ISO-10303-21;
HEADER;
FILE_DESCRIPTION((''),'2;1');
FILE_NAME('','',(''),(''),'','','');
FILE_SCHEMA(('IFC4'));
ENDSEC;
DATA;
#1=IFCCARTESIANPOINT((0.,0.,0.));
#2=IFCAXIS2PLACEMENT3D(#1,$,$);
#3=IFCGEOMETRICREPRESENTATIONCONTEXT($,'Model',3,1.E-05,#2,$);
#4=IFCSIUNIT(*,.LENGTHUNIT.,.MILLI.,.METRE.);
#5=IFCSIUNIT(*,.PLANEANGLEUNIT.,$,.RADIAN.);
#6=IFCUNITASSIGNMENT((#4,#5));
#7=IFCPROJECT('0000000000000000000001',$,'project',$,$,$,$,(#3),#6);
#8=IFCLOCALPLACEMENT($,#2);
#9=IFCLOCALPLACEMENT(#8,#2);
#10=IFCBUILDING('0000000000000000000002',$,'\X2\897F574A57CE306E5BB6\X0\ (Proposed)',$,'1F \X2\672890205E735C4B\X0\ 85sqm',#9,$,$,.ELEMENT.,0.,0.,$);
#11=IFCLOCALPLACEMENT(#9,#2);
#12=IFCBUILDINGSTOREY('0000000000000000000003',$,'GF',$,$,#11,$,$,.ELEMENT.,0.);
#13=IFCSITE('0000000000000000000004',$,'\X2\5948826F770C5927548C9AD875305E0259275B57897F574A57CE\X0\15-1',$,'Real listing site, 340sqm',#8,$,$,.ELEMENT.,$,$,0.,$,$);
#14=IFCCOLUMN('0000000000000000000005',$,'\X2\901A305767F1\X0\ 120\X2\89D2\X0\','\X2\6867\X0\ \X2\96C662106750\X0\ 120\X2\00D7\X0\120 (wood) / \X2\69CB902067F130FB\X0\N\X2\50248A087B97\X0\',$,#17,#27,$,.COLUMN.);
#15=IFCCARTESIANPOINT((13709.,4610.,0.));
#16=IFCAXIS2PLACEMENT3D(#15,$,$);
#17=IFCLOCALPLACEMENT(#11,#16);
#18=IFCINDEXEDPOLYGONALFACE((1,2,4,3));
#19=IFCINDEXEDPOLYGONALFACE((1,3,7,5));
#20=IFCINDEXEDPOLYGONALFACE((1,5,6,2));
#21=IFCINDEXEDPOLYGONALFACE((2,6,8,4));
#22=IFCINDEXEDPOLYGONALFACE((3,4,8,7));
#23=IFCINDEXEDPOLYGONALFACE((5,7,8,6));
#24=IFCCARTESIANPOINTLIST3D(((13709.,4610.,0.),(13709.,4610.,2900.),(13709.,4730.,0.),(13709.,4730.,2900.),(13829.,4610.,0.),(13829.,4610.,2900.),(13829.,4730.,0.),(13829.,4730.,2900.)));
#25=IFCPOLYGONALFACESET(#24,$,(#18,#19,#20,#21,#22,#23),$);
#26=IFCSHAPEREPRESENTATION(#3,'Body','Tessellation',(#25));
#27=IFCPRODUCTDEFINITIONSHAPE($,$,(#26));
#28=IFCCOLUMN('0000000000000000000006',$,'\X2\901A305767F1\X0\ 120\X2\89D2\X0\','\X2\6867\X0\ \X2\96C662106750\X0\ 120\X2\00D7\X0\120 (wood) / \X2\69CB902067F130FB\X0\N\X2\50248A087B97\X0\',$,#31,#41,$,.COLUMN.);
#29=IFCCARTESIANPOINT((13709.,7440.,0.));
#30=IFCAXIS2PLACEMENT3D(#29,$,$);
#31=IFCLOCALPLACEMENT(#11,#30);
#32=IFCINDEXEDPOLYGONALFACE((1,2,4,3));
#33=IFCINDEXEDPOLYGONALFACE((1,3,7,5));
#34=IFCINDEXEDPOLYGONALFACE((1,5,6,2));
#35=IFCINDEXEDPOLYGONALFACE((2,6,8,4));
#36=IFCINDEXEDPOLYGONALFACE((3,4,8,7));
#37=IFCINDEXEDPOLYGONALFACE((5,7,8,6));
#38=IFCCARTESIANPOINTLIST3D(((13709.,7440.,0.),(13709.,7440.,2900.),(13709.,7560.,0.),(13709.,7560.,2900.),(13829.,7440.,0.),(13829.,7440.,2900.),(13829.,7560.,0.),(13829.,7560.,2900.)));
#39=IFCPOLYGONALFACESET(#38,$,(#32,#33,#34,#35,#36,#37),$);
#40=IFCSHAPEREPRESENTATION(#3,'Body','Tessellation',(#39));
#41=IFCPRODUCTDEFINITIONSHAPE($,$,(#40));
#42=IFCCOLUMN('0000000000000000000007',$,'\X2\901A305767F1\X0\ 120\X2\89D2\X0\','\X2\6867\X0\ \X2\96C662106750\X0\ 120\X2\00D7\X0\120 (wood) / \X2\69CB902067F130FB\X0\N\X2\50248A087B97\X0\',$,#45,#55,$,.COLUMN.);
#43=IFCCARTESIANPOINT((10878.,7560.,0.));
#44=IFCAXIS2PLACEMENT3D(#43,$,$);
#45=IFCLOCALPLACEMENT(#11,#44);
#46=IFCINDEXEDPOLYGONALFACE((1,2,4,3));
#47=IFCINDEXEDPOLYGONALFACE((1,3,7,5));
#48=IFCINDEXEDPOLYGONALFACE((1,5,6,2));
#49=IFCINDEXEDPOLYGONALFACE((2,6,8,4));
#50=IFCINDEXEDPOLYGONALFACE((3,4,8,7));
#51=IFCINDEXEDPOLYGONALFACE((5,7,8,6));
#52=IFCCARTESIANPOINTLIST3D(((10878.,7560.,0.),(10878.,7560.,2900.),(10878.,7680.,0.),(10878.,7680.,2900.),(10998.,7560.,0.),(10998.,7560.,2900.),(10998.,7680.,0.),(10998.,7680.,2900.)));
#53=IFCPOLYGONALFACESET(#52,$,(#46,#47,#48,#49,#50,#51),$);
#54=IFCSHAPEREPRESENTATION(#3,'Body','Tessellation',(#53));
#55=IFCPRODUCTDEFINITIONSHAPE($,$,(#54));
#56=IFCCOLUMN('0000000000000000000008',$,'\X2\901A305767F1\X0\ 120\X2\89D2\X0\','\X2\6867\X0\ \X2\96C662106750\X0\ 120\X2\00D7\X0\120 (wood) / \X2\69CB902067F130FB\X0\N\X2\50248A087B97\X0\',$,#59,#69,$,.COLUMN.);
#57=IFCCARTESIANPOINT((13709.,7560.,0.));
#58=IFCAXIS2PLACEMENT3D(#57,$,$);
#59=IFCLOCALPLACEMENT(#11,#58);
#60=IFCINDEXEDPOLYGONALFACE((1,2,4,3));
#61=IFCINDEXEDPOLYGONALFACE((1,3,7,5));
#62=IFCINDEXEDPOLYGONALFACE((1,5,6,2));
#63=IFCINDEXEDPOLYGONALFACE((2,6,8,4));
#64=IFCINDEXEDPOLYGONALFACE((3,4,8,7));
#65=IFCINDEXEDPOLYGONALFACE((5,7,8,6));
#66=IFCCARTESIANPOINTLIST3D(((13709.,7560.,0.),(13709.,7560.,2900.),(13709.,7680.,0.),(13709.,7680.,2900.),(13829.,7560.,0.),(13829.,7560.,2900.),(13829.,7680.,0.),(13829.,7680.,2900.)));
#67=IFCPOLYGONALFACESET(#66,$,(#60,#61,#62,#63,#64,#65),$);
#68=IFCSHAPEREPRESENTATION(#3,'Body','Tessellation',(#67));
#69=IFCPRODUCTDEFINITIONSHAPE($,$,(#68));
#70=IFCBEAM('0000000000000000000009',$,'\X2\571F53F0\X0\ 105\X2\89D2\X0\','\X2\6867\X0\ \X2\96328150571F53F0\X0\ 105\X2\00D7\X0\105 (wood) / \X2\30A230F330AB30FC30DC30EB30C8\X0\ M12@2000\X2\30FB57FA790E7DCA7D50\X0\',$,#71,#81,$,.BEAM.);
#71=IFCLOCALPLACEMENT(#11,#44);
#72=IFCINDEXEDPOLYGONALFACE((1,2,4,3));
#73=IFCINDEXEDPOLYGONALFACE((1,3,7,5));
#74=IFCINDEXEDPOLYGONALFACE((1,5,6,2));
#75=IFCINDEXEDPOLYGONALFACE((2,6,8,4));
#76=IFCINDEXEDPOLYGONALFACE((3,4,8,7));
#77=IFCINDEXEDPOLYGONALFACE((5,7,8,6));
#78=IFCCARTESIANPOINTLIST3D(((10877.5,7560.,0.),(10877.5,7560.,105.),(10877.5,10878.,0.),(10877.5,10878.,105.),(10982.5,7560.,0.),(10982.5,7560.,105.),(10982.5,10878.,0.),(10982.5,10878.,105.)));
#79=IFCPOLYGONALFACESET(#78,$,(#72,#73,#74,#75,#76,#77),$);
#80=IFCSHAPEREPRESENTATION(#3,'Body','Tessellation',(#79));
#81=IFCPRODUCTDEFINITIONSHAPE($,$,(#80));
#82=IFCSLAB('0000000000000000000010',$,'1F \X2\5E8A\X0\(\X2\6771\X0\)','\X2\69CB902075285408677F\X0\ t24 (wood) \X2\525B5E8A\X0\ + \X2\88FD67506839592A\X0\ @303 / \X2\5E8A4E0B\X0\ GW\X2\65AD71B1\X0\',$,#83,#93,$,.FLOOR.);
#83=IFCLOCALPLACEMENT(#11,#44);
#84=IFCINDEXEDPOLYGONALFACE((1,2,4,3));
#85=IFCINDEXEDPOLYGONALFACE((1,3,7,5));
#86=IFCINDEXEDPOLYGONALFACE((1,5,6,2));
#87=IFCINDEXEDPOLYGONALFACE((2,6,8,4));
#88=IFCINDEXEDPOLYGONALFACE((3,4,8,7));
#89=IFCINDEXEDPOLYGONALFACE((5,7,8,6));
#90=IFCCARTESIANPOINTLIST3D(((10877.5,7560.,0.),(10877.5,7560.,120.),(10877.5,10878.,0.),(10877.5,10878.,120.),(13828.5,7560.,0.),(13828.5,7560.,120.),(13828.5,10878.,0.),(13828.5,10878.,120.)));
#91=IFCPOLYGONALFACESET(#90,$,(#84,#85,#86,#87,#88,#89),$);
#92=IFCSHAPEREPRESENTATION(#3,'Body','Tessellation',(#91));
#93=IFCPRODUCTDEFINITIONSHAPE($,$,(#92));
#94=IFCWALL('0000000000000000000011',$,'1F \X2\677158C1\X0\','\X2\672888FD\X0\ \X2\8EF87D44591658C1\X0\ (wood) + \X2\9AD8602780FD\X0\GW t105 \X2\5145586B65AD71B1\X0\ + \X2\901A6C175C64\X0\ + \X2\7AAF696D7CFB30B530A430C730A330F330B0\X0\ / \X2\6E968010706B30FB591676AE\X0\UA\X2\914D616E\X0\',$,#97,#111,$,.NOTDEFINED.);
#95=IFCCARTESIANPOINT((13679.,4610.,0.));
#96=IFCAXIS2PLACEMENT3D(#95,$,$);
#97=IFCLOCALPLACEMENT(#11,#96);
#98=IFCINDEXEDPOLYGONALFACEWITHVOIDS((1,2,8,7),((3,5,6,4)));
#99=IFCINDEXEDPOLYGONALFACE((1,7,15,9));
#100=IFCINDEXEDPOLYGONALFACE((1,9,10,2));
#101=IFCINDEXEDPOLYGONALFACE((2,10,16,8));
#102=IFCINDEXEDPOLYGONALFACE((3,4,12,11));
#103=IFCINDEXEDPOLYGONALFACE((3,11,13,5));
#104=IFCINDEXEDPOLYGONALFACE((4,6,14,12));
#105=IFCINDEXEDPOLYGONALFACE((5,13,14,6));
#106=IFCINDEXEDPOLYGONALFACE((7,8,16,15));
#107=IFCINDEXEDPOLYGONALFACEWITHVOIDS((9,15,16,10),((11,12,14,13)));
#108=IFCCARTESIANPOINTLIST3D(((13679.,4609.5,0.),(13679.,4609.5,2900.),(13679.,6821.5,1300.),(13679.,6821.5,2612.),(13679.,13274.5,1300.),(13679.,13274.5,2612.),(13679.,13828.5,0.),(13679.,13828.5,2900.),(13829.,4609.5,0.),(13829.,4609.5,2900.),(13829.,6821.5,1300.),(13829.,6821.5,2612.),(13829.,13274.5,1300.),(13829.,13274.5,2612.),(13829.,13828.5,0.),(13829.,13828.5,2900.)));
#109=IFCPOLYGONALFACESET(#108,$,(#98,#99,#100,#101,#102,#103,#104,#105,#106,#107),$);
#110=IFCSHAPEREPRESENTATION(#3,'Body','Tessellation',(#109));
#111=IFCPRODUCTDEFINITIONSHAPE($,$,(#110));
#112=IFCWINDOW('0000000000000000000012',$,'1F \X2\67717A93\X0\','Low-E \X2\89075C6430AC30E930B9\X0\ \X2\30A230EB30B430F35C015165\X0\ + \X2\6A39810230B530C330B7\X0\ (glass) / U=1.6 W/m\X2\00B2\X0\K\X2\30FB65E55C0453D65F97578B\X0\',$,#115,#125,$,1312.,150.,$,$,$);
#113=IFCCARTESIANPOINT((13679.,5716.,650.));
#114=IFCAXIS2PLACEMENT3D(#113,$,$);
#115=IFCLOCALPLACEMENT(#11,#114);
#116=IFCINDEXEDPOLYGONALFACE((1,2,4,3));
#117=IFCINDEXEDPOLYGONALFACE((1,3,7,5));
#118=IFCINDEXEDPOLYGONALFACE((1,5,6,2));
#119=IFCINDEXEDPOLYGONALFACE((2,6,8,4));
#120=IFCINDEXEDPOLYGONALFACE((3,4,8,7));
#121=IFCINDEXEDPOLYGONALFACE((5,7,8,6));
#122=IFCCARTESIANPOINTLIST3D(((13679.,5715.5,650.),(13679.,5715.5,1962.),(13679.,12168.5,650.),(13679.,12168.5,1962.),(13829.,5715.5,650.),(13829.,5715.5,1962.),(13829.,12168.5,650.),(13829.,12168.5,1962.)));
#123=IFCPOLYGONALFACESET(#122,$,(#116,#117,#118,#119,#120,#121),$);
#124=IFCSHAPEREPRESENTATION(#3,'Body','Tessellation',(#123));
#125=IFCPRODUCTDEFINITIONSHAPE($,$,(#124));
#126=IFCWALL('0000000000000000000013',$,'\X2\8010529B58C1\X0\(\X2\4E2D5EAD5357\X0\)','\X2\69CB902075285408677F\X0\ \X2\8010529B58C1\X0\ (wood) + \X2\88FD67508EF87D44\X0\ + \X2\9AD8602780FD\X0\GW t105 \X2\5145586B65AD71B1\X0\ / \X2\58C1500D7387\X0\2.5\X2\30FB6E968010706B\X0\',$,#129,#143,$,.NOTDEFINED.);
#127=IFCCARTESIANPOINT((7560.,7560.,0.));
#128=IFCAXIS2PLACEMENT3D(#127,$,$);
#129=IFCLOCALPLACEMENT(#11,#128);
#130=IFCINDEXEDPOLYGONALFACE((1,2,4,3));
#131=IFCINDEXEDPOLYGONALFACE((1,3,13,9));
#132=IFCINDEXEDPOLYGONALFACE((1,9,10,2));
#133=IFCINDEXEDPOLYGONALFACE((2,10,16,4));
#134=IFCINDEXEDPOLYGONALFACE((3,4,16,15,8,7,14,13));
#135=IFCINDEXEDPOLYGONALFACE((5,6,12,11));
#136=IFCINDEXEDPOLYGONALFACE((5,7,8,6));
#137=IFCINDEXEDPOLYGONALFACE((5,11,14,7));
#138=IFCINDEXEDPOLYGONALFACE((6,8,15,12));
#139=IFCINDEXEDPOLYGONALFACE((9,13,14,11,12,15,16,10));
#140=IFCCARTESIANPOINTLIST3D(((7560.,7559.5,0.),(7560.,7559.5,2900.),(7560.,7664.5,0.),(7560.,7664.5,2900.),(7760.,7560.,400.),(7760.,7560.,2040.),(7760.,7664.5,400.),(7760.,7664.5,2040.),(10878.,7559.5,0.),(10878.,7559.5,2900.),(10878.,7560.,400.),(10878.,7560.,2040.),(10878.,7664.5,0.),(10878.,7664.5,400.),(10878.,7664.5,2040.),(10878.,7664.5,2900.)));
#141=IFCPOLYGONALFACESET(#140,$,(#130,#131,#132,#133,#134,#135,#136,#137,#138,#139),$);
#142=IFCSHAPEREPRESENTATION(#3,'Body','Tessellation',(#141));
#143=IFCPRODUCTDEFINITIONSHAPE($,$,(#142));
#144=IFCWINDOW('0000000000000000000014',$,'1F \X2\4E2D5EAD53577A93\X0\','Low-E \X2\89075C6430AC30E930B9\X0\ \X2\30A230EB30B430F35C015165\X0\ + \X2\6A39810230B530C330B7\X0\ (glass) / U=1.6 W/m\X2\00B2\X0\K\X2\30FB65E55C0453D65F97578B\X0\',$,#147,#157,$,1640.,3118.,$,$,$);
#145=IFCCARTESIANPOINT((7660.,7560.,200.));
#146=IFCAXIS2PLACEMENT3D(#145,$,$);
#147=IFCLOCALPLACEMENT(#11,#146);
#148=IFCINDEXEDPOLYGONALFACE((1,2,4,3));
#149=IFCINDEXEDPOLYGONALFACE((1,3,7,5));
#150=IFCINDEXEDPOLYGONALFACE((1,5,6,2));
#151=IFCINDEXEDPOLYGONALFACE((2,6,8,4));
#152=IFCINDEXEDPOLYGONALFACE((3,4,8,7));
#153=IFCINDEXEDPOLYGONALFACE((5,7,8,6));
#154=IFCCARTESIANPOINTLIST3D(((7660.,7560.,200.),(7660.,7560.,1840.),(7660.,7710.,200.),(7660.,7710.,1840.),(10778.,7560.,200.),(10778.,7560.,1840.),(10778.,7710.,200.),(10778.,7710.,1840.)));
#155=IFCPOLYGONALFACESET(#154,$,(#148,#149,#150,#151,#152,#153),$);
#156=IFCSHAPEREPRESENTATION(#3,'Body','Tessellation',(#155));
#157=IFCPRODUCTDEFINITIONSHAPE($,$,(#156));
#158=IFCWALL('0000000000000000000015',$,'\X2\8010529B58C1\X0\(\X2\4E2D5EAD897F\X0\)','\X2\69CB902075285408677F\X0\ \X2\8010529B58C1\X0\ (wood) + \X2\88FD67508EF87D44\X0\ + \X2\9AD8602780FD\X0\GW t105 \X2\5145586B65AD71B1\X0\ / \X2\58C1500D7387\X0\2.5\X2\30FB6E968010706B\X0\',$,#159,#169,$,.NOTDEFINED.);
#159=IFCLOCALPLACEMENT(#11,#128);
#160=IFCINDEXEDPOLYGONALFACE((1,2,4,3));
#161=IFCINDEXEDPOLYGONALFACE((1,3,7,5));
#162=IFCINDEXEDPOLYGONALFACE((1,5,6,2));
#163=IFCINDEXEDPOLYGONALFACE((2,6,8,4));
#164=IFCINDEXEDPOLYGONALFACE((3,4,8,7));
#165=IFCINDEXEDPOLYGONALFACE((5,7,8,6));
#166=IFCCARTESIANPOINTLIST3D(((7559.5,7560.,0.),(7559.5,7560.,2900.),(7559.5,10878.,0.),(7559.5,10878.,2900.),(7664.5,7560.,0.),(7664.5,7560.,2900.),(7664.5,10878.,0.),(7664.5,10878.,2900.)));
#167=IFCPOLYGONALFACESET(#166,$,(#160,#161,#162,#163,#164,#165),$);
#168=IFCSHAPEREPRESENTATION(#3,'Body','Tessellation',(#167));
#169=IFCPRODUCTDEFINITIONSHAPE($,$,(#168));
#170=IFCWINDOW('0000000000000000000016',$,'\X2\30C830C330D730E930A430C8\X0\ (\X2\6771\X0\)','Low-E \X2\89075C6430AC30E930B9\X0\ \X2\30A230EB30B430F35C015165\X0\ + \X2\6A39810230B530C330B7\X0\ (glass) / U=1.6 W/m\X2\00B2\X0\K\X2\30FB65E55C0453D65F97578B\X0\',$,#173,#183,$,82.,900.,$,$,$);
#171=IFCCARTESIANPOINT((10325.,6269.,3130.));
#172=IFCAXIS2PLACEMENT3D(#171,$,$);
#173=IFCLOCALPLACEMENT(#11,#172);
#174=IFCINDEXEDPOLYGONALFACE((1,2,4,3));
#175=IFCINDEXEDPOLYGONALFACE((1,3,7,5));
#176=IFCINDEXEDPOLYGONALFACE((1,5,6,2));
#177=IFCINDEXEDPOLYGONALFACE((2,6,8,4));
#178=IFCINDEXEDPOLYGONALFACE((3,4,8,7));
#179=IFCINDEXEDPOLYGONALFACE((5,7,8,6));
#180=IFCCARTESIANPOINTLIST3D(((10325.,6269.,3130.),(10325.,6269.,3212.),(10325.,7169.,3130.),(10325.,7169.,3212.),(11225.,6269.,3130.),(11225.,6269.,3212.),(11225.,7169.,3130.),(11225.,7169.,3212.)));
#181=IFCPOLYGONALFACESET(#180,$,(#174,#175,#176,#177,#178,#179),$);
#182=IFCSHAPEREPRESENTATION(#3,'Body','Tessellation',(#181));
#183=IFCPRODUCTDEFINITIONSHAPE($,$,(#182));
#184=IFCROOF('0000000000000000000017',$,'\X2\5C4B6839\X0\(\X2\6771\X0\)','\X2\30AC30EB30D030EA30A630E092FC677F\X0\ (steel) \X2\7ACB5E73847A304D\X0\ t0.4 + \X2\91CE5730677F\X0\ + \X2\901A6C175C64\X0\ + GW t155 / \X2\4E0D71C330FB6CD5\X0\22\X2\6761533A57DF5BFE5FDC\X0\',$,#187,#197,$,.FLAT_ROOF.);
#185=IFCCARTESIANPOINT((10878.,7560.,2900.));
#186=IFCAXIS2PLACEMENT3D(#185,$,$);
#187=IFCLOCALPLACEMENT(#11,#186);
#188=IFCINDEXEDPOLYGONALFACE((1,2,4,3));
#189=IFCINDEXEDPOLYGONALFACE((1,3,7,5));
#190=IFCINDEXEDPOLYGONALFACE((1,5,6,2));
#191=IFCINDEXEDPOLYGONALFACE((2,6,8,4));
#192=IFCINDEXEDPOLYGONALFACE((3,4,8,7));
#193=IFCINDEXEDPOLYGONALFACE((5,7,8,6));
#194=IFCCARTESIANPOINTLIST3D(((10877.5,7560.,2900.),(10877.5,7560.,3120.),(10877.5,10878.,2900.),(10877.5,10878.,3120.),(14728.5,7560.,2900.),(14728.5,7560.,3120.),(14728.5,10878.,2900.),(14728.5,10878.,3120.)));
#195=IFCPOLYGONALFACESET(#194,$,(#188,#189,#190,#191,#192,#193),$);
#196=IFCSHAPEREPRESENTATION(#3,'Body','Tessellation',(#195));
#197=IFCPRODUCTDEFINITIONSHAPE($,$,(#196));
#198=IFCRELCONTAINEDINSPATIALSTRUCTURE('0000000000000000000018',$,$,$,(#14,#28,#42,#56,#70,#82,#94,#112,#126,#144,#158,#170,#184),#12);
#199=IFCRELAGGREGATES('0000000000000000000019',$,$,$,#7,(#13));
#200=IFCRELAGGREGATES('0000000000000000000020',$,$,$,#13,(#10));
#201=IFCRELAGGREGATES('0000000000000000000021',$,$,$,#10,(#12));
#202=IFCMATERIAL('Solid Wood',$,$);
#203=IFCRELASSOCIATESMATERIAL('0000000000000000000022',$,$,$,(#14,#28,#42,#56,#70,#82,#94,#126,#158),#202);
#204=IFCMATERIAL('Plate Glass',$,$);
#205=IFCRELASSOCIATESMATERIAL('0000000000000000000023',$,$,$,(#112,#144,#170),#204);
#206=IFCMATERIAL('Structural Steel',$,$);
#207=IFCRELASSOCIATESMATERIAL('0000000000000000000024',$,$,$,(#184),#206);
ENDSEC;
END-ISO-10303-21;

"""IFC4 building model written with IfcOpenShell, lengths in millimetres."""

from ifc_helpers import new_model, si_unit, frame, frame_2d, origin, place, context, project, spatial, rectangle, extrude, material, element, fill, save


model = new_model("IFC4")

# Units and contexts
model_context = context("Model", 3, precision=1e-05, world=origin())
ifc_project = project(units=[si_unit("LENGTHUNIT", "METRE", prefix="MILLI"), si_unit("PLANEANGLEUNIT", "RADIAN")], contexts=[model_context])

# Site, building, storey
site_placement = place(None, origin())
site = spatial("IfcSite", under=ifc_project, at=site_placement, Name="奈良県大和高田市大字西坊城15-1", ObjectType="Real listing site, 340sqm", CompositionType="ELEMENT", RefElevation=0.0)
building_placement = place(site_placement, origin())
building = spatial("IfcBuilding", under=site, at=building_placement, Name="西坊城の家 (Proposed)", ObjectType="1F 木造平屋 85sqm", CompositionType="ELEMENT", ElevationOfRefHeight=0.0, ElevationOfTerrain=0.0)
storey_placement = place(building_placement, origin())
storey = spatial("IfcBuildingStorey", under=building, at=storey_placement, Name="GF", CompositionType="ELEMENT", Elevation=0.0)

# Columns
ifc_material_1 = material(Name="Solid Wood")
column_1_placement = place(storey_placement, frame((13709.0, 4610.0, 0.0)))
element("IfcColumn", 1, at=column_1_placement, inside=storey, material=ifc_material_1, Name="通し柱 120角", Description="桧 集成材 120×120 (wood) / 構造柱・N値計算", PredefinedType="COLUMN", context=model_context, shape_type="SweptSolid", body=[
    extrude(rectangle(XDim=120.0, YDim=120.0, at=frame_2d((60.0, 60.0))), frame((13709.0, 4610.0, 0.0)), (0.0, 0.0, 1.0), 2900.0),
])
column_2_placement = place(storey_placement, frame((13709.0, 7440.0, 0.0)))
element("IfcColumn", 2, at=column_2_placement, inside=storey, material=ifc_material_1, Name="通し柱 120角", Description="桧 集成材 120×120 (wood) / 構造柱・N値計算", PredefinedType="COLUMN", context=model_context, shape_type="SweptSolid", body=[
    extrude(rectangle(XDim=120.0, YDim=120.0, at=frame_2d((60.0, 60.0))), frame((13709.0, 7440.0, 0.0)), (0.0, 0.0, 1.0), 2900.0),
])
column_3_placement = place(storey_placement, frame((10878.0, 7560.0, 0.0)))
element("IfcColumn", 3, at=column_3_placement, inside=storey, material=ifc_material_1, Name="通し柱 120角", Description="桧 集成材 120×120 (wood) / 構造柱・N値計算", PredefinedType="COLUMN", context=model_context, shape_type="SweptSolid", body=[
    extrude(rectangle(XDim=120.0, YDim=120.0, at=frame_2d((60.0, 60.0))), frame((10878.0, 7560.0, 0.0)), (0.0, 0.0, 1.0), 2900.0),
])
column_4_placement = place(storey_placement, frame((13709.0, 7560.0, 0.0)))
element("IfcColumn", 4, at=column_4_placement, inside=storey, material=ifc_material_1, Name="通し柱 120角", Description="桧 集成材 120×120 (wood) / 構造柱・N値計算", PredefinedType="COLUMN", context=model_context, shape_type="SweptSolid", body=[
    extrude(rectangle(XDim=120.0, YDim=120.0, at=frame_2d((60.0, 60.0))), frame((13709.0, 7560.0, 0.0)), (0.0, 0.0, 1.0), 2900.0),
])

# Beam
beam_1_placement = place(storey_placement, frame((10878.0, 7560.0, 0.0)))
element("IfcBeam", 5, at=beam_1_placement, inside=storey, material=ifc_material_1, Name="土台 105角", Description="桧 防腐土台 105×105 (wood) / アンカーボルト M12@2000・基礎緊結", PredefinedType="BEAM", context=model_context, shape_type="SweptSolid", body=[
    extrude(rectangle(XDim=105.0, YDim=3318.0, at=frame_2d((52.0, 1659.0))), frame((10878.0, 7560.0, 0.0)), (0.0, 0.0, 1.0), 105.0),
])

# Slab
slab_placement = place(storey_placement, frame((10878.0, 7560.0, 0.0)))
element("IfcSlab", 6, at=slab_placement, inside=storey, material=ifc_material_1, Name="1F 床(東)", Description="構造用合板 t24 (wood) 剛床 + 製材根太 @303 / 床下 GW断熱", PredefinedType="FLOOR", context=model_context, shape_type="SweptSolid", body=[
    extrude(rectangle(XDim=2951.0, YDim=3318.0, at=frame_2d((1475.0, 1659.0))), frame((10878.0, 7560.0, 0.0)), (0.0, 0.0, 1.0), 120.0),
])

# Walls, openings, windows
wall_1_placement = place(storey_placement, frame((13679.0, 4610.0, 0.0)))
wall_1 = element("IfcWall", 7, at=wall_1_placement, inside=storey, material=ifc_material_1, Name="1F 東壁", Description="木製 軸組外壁 (wood) + 高性能GW t105 充填断熱 + 通気層 + 窯業系サイディング / 準耐火・外皮UA配慮", PredefinedType="NOTDEFINED", context=model_context, shape_type="SweptSolid", body=[
    extrude(rectangle(XDim=150.0, YDim=9219.0, at=frame_2d((75.0, 4609.0))), frame((13679.0, 4610.0, 0.0)), (0.0, 0.0, 1.0), 2900.0),
])
opening_1_placement = place(storey_placement, frame((13679.0, 5716.0, 650.0)))
opening_1 = element("IfcOpeningElement", 8, at=opening_1_placement, cuts=wall_1, PredefinedType="NOTDEFINED", context=model_context, shape_type="SweptSolid", body=[
    extrude(rectangle(XDim=150.0, YDim=6453.0, at=frame_2d((75.0, 3226.0))), frame((13679.0, 5716.0, 650.0)), (0.0, 0.0, 1.0), 1312.0),
])
ifc_material_2 = material(Name="Plate Glass")
window_1_placement = place(storey_placement, frame((13679.0, 5716.0, 650.0)))
window_1 = element("IfcWindow", 9, at=window_1_placement, inside=storey, material=ifc_material_2, Name="1F 東窓", Description="Low-E 複層ガラス アルゴン封入 + 樹脂サッシ (glass) / U=1.6 W/m²K・日射取得型", OverallHeight=1312.0, OverallWidth=150.0, context=model_context, shape_type="SweptSolid", body=[
    extrude(rectangle(XDim=150.0, YDim=6453.0, at=frame_2d((75.0, 3226.0))), frame((13679.0, 5716.0, 650.0)), (0.0, 0.0, 1.0), 1312.0),
])
fill(opening_1, window_1)
wall_2_placement = place(storey_placement, frame((7560.0, 7560.0, 0.0)))
wall_2 = element("IfcWall", 10, at=wall_2_placement, inside=storey, material=ifc_material_1, Name="耐力壁(中庭南)", Description="構造用合板 耐力壁 (wood) + 製材軸組 + 高性能GW t105 充填断熱 / 壁倍率2.5・準耐火", PredefinedType="NOTDEFINED", context=model_context, shape_type="SweptSolid", body=[
    extrude(rectangle(XDim=3318.0, YDim=105.0, at=frame_2d((1659.0, 52.0))), frame((7560.0, 7560.0, 0.0)), (0.0, 0.0, 1.0), 2900.0),
])
opening_2_placement = place(storey_placement, frame((7660.0, 7560.0, 200.0)))
opening_2 = element("IfcOpeningElement", 11, at=opening_2_placement, cuts=wall_2, PredefinedType="NOTDEFINED", context=model_context, shape_type="SweptSolid", body=[
    extrude(rectangle(XDim=3118.0, YDim=150.0, at=frame_2d((1559.0, 75.0))), frame((7660.0, 7560.0, 200.0)), (0.0, 0.0, 1.0), 1640.0),
])
window_2_placement = place(storey_placement, frame((7660.0, 7560.0, 200.0)))
window_2 = element("IfcWindow", 12, at=window_2_placement, inside=storey, material=ifc_material_2, Name="1F 中庭南窓", Description="Low-E 複層ガラス アルゴン封入 + 樹脂サッシ (glass) / U=1.6 W/m²K・日射取得型", OverallHeight=1640.0, OverallWidth=3118.0, context=model_context, shape_type="SweptSolid", body=[
    extrude(rectangle(XDim=3118.0, YDim=150.0, at=frame_2d((1559.0, 75.0))), frame((7660.0, 7560.0, 200.0)), (0.0, 0.0, 1.0), 1640.0),
])
fill(opening_2, window_2)

# Wall
wall_3_placement = place(storey_placement, frame((7560.0, 7560.0, 0.0)))
element("IfcWall", 13, at=wall_3_placement, inside=storey, material=ifc_material_1, Name="耐力壁(中庭西)", Description="構造用合板 耐力壁 (wood) + 製材軸組 + 高性能GW t105 充填断熱 / 壁倍率2.5・準耐火", PredefinedType="NOTDEFINED", context=model_context, shape_type="SweptSolid", body=[
    extrude(rectangle(XDim=105.0, YDim=3318.0, at=frame_2d((52.0, 1659.0))), frame((7560.0, 7560.0, 0.0)), (0.0, 0.0, 1.0), 2900.0),
])

# Window
window_3_placement = place(storey_placement, frame((10325.0, 6269.0, 3130.0)))
element("IfcWindow", 14, at=window_3_placement, inside=storey, material=ifc_material_2, Name="トップライト (東)", Description="Low-E 複層ガラス アルゴン封入 + 樹脂サッシ (glass) / U=1.6 W/m²K・日射取得型", OverallHeight=82.0, OverallWidth=900.0, context=model_context, shape_type="SweptSolid", body=[
    extrude(rectangle(XDim=900.0, YDim=900.0, at=frame_2d((450.0, 450.0))), frame((10325.0, 6269.0, 3130.0)), (0.0, 0.0, 1.0), 82.0),
])

# Roof
ifc_material_3 = material(Name="Structural Steel")
roof_placement = place(storey_placement, frame((10878.0, 7560.0, 2900.0)))
element("IfcRoof", 15, at=roof_placement, inside=storey, material=ifc_material_3, Name="屋根(東)", Description="ガルバリウム鋼板 (steel) 立平葺き t0.4 + 野地板 + 通気層 + GW t155 / 不燃・法22条区域対応", PredefinedType="FLAT_ROOF", context=model_context, shape_type="SweptSolid", body=[
    extrude(rectangle(XDim=3851.0, YDim=3318.0, at=frame_2d((1925.0, 1659.0))), frame((10878.0, 7560.0, 2900.0)), (0.0, 0.0, 1.0), 220.0),
])

save(model, "model.ifc")
